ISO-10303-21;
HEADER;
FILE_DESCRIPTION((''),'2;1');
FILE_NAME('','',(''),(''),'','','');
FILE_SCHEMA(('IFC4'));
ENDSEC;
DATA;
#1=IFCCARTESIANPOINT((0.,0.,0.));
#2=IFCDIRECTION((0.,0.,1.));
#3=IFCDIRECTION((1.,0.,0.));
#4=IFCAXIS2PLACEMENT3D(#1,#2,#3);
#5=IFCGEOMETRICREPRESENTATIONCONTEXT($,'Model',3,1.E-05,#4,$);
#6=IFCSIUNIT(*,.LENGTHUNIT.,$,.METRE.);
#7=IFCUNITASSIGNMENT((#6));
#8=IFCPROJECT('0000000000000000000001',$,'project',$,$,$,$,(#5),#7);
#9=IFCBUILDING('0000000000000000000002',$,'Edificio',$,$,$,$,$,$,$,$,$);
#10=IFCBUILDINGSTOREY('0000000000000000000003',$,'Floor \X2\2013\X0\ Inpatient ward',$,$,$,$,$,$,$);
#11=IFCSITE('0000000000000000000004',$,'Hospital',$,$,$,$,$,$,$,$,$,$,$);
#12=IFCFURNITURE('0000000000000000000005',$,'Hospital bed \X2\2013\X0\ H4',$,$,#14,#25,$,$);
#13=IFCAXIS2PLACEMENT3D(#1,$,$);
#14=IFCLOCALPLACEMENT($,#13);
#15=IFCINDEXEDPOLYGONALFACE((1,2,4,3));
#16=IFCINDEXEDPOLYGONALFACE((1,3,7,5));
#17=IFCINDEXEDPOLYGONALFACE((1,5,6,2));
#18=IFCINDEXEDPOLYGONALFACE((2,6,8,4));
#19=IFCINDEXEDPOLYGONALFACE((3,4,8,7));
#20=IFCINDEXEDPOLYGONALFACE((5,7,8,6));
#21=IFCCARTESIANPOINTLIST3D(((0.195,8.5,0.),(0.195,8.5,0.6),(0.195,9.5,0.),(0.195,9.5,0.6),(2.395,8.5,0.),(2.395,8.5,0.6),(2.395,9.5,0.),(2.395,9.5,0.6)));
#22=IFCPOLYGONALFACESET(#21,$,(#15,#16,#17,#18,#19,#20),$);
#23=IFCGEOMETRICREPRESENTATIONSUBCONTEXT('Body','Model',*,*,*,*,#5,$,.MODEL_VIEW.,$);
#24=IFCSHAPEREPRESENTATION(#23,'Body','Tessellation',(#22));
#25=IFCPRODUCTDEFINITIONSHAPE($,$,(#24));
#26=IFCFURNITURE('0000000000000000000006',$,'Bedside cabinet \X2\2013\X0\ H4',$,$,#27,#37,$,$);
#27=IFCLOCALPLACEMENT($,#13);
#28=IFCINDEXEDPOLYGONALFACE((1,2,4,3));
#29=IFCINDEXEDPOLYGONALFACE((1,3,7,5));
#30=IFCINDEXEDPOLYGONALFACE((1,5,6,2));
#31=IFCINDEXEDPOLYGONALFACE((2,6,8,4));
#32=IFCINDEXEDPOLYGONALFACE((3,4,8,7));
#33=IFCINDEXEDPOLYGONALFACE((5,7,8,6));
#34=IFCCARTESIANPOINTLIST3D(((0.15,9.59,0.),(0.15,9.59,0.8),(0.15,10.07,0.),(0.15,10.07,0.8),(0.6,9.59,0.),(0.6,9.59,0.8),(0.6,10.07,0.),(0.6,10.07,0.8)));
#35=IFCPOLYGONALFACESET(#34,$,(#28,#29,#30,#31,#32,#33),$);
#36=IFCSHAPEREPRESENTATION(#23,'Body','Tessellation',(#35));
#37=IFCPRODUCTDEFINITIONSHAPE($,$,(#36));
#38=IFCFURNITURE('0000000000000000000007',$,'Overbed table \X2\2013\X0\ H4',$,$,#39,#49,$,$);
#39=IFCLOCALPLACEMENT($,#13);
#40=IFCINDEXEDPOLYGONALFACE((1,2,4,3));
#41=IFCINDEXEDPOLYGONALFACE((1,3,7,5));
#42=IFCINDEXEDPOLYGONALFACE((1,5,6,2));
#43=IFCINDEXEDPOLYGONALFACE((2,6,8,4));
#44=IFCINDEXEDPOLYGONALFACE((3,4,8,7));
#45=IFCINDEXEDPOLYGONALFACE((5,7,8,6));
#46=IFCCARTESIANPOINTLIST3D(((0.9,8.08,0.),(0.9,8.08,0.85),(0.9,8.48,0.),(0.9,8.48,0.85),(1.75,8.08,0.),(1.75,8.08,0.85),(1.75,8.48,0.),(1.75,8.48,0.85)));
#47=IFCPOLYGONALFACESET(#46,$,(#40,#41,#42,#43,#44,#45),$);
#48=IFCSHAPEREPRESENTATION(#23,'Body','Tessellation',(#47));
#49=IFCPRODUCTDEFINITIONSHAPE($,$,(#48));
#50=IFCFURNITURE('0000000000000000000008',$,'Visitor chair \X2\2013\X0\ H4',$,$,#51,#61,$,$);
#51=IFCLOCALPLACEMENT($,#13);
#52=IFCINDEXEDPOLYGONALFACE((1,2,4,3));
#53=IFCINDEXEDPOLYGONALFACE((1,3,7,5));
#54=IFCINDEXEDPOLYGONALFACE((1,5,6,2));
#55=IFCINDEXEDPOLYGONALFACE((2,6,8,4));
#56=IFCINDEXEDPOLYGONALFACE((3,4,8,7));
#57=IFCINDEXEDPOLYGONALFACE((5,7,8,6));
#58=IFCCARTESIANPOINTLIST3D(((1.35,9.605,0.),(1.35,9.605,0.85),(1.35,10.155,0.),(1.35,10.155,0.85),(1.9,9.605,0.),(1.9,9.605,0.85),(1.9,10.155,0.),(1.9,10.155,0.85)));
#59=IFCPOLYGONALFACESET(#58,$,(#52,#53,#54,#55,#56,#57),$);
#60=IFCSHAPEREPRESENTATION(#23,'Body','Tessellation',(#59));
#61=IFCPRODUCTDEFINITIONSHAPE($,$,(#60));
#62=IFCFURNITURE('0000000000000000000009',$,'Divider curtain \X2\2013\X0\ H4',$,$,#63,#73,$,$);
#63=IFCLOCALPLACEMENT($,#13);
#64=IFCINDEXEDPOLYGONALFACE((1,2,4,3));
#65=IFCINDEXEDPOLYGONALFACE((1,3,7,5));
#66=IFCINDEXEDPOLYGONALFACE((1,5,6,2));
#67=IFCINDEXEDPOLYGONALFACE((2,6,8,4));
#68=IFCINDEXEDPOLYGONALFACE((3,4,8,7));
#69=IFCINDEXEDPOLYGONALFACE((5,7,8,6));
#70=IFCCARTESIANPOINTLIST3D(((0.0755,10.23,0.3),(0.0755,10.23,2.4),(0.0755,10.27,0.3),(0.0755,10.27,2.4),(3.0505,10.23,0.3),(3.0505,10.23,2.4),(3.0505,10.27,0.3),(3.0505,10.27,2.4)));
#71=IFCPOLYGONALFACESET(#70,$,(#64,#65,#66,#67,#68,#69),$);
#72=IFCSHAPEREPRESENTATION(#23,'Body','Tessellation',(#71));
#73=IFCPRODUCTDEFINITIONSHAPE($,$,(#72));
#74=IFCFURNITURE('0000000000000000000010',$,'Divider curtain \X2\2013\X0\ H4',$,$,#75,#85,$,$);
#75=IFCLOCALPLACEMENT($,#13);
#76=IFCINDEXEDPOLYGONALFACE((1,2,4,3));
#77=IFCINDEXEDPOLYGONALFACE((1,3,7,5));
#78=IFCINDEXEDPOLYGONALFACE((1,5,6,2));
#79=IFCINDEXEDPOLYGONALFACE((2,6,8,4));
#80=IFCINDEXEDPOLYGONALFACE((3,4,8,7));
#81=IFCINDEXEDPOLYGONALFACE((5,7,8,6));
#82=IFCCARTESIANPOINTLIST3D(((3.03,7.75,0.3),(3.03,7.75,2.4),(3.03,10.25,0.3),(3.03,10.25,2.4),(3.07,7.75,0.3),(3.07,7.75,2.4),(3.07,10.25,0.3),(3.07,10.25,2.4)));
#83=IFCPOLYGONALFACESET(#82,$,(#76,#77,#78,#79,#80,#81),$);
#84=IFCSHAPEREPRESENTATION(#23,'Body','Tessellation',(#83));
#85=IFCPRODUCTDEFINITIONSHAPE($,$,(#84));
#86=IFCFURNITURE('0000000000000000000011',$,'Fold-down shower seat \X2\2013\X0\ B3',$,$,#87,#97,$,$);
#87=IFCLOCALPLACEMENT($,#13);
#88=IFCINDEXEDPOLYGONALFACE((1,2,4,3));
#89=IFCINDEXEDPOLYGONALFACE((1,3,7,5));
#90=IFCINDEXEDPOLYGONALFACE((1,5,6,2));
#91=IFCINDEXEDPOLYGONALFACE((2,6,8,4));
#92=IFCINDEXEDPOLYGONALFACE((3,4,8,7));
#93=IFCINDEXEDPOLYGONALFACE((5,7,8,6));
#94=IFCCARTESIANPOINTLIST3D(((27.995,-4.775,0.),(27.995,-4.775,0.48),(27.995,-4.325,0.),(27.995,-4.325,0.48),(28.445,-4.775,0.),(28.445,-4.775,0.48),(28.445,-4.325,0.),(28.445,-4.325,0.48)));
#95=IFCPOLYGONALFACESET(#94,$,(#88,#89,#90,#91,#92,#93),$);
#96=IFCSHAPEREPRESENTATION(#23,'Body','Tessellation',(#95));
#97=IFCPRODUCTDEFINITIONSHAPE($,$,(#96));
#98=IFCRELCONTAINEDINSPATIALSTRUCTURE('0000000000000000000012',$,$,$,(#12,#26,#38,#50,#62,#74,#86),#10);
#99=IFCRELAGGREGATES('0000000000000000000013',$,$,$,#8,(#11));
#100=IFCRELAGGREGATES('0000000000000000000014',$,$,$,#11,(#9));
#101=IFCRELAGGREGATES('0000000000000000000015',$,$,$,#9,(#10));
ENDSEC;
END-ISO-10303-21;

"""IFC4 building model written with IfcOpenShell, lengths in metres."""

from ifc_helpers import new_model, si_unit, frame, origin_with_axes, context, subcontext, project, spatial, line, indexed_curve, outline, extrude, element, save


model = new_model("IFC4")

# Units and contexts
model_context = context("Model", 3, precision=1e-05, world=origin_with_axes())
body_context = subcontext(model_context, "Body", "Model", "MODEL_VIEW")
ifc_project = project(units=[si_unit("LENGTHUNIT", "METRE")], contexts=[model_context])

# Site, building, storey
site = spatial("IfcSite", under=ifc_project, Name="Hospital")
building = spatial("IfcBuilding", under=site, Name="Edificio")
storey = spatial("IfcBuildingStorey", under=building, Name="Floor – Inpatient ward")

# Furniture
element("IfcFurniture", 1, inside=storey, Name="Hospital bed – H4", context=body_context, shape_type="SweptSolid", body=[
    extrude(outline(indexed_curve([(0.0, 0.0), (2.2, 0.0), (2.2, 1.0), (0.0, 1.0)], segments=[line(1, 2, 3, 4, 1)])), frame((0.195, 8.5, 0.0), z_axis=(0.0, 0.0, 1.0), x_axis=(1.0, 0.0, 0.0)), (0.0, 0.0, 1.0), 0.6),
])
element("IfcFurniture", 2, inside=storey, Name="Bedside cabinet – H4", context=body_context, shape_type="SweptSolid", body=[
    extrude(outline(indexed_curve([(0.0, 0.0), (0.45, 0.0), (0.45, 0.48), (0.0, 0.48)], segments=[line(1, 2, 3, 4, 1)])), frame((0.15, 9.59, 0.0), z_axis=(0.0, 0.0, 1.0), x_axis=(1.0, 0.0, 0.0)), (0.0, 0.0, 1.0), 0.8),
])
element("IfcFurniture", 3, inside=storey, Name="Overbed table – H4", context=body_context, shape_type="SweptSolid", body=[
    extrude(outline(indexed_curve([(0.0, 0.0), (0.85, 0.0), (0.85, 0.4), (0.0, 0.4)], segments=[line(1, 2, 3, 4, 1)])), frame((0.9, 8.08, 0.0), z_axis=(0.0, 0.0, 1.0), x_axis=(1.0, 0.0, 0.0)), (0.0, 0.0, 1.0), 0.85),
])
element("IfcFurniture", 4, inside=storey, Name="Visitor chair – H4", context=body_context, shape_type="SweptSolid", body=[
    extrude(outline(indexed_curve([(0.0, 0.0), (0.55, 0.0), (0.55, 0.55), (0.0, 0.55)], segments=[line(1, 2, 3, 4, 1)])), frame((1.35, 9.605, 0.0), z_axis=(0.0, 0.0, 1.0), x_axis=(1.0, 0.0, 0.0)), (0.0, 0.0, 1.0), 0.85),
])
element("IfcFurniture", 5, inside=storey, Name="Divider curtain – H4", context=body_context, shape_type="SweptSolid", body=[
    extrude(outline(indexed_curve([(0.0, 0.0), (2.975, 0.0), (2.975, 0.04), (0.0, 0.04)], segments=[line(1, 2, 3, 4, 1)])), frame((0.0755, 10.23, 0.3), z_axis=(0.0, 0.0, 1.0), x_axis=(1.0, 0.0, 0.0)), (0.0, 0.0, 1.0), 2.1),
])
element("IfcFurniture", 6, inside=storey, Name="Divider curtain – H4", context=body_context, shape_type="SweptSolid", body=[
    extrude(outline(indexed_curve([(0.0, 0.0), (0.04, 0.0), (0.04, 2.5), (0.0, 2.5)], segments=[line(1, 2, 3, 4, 1)])), frame((3.03, 7.75, 0.3), z_axis=(0.0, 0.0, 1.0), x_axis=(1.0, 0.0, 0.0)), (0.0, 0.0, 1.0), 2.1),
])
element("IfcFurniture", 7, inside=storey, Name="Fold-down shower seat – B3", context=body_context, shape_type="SweptSolid", body=[
    extrude(outline(indexed_curve([(0.0, 0.0), (0.45, 0.0), (0.45, 0.45), (0.0, 0.45)], segments=[line(1, 2, 3, 4, 1)])), frame((27.995, -4.775, 0.0), z_axis=(0.0, 0.0, 1.0), x_axis=(1.0, 0.0, 0.0)), (0.0, 0.0, 1.0), 0.48),
])

save(model, "model.ifc")
